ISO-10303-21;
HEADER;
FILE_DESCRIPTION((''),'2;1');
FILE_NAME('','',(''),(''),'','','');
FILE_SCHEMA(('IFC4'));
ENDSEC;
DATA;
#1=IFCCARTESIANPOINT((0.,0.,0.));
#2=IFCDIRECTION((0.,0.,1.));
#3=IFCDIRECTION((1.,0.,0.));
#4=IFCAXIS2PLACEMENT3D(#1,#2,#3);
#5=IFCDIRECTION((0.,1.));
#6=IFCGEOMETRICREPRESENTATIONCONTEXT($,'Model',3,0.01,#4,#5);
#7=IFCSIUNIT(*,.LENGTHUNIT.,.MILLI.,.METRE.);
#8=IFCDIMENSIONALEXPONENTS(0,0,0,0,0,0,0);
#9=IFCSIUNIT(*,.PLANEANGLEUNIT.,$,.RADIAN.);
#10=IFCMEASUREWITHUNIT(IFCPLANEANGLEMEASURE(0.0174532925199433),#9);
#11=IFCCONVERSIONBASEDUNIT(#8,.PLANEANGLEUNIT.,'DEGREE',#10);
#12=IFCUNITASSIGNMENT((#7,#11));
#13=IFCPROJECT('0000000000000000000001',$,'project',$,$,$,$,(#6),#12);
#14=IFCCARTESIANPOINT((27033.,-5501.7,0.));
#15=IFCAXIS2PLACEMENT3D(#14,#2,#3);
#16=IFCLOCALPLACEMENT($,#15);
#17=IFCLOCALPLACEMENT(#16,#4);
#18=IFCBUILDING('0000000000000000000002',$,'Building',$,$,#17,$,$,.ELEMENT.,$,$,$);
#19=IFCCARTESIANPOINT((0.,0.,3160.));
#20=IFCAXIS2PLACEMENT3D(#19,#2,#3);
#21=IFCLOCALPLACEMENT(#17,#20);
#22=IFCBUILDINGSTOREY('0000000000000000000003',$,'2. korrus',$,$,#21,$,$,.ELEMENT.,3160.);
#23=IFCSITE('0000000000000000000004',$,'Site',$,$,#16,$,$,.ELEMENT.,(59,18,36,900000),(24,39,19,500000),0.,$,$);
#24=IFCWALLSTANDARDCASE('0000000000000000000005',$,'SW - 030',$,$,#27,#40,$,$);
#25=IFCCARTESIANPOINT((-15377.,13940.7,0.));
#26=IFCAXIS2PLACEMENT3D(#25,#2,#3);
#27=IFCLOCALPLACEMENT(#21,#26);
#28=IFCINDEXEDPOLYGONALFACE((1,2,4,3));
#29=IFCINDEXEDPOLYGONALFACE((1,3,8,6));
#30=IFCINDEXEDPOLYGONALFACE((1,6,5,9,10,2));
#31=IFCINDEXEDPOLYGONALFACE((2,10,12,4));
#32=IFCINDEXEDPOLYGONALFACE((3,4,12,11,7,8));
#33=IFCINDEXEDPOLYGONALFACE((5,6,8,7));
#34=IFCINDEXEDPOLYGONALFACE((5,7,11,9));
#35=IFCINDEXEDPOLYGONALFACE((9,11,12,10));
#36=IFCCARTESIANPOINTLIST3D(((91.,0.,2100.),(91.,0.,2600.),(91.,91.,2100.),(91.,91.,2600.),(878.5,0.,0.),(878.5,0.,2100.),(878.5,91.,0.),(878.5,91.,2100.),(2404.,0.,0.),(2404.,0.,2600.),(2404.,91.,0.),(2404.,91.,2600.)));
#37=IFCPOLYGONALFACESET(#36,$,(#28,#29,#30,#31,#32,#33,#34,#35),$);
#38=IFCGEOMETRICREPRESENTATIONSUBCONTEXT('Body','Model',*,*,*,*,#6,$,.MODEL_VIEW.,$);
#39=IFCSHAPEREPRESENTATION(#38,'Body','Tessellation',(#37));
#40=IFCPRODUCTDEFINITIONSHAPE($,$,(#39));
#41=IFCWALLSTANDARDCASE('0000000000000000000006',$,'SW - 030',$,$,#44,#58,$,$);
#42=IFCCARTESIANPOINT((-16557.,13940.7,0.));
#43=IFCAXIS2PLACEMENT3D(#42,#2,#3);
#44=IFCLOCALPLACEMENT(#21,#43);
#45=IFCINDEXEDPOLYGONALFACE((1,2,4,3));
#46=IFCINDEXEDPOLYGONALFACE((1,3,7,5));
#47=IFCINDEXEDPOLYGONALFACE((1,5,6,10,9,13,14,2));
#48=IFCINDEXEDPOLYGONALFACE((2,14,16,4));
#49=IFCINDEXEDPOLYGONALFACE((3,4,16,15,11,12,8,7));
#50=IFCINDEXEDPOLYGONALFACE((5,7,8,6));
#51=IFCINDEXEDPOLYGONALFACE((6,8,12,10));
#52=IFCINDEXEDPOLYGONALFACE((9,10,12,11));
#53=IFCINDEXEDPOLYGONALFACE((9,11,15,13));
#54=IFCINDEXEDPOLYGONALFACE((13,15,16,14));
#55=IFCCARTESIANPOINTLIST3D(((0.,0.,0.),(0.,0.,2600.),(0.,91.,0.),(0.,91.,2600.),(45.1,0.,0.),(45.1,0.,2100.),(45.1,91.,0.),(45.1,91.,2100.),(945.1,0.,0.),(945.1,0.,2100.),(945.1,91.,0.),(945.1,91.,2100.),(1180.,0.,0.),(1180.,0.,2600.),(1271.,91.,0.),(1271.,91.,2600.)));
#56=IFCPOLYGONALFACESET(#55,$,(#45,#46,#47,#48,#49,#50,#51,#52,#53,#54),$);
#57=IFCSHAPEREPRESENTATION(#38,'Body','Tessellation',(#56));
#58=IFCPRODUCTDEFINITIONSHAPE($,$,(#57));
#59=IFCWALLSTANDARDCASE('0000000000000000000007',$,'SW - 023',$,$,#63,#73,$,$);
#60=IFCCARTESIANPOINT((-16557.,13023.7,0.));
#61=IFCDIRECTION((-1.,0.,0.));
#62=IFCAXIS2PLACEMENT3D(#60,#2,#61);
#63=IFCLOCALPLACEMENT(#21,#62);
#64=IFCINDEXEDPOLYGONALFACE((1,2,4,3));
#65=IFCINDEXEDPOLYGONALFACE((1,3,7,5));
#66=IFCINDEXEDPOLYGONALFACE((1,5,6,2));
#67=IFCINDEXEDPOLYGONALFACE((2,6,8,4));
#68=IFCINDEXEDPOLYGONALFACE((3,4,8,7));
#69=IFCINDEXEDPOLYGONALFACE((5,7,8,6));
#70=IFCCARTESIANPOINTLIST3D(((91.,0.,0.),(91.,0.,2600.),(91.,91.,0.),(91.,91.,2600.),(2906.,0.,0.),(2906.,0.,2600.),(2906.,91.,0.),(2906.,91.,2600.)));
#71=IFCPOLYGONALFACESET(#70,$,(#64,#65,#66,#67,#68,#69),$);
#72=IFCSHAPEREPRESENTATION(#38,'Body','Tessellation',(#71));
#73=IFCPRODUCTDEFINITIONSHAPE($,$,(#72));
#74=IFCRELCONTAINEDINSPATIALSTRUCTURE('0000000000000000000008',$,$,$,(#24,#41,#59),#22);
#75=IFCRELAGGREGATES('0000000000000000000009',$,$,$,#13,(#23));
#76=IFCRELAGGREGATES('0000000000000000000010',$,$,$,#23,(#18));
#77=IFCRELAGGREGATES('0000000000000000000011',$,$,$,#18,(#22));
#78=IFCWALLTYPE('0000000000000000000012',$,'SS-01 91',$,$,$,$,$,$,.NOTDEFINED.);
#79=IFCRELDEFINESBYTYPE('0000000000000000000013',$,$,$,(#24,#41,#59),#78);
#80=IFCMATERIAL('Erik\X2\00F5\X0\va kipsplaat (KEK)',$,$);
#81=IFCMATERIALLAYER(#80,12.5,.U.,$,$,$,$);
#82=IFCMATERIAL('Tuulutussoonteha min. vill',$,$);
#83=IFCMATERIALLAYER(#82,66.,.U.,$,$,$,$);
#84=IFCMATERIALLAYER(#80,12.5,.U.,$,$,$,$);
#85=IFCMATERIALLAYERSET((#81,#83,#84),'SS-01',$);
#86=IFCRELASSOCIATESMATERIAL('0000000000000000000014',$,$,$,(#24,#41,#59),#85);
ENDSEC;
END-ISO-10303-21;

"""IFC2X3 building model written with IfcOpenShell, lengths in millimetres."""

from ifc_helpers import new_model, entity, si_unit, converted_unit, direction, frame, origin_with_axes, origin_2d_with_axis, place, context, subcontext, project, spatial, polyline, rectangle, outline, extrude, material, layer, layer_set, layer_usage, type_object, element, save


model = new_model("IFC2X3")

# Units and contexts
model_context = context("Model", 3, precision=0.01, world=origin_with_axes(), true_north=direction((0.0, 1.0)))
body_context = subcontext(model_context, "Body", "Model", "MODEL_VIEW")
ifc_project = project(units=[si_unit("LENGTHUNIT", "METRE", prefix="MILLI"), converted_unit("PLANEANGLEUNIT", "DEGREE", entity("IfcPlaneAngleMeasure", 0.0174532925199433), si_unit("PLANEANGLEUNIT", "RADIAN"), dimensions=[0, 0, 0, 0, 0, 0, 0])], contexts=[model_context])

# Site, building, storey
site_placement = place(None, frame((27033.0, -5501.7, 0.0), z_axis=(0.0, 0.0, 1.0), x_axis=(1.0, 0.0, 0.0)))
site = spatial("IfcSite", under=ifc_project, at=site_placement, Name="Site", CompositionType="ELEMENT", RefLatitude=(59, 18, 36, 900000), RefLongitude=(24, 39, 19, 500000), RefElevation=0.0)
building_placement = place(site_placement, origin_with_axes())
building = spatial("IfcBuilding", under=site, at=building_placement, Name="Building", CompositionType="ELEMENT")
storey_placement = place(building_placement, frame((0.0, 0.0, 3160.0), z_axis=(0.0, 0.0, 1.0), x_axis=(1.0, 0.0, 0.0)))
storey = spatial("IfcBuildingStorey", under=building, at=storey_placement, Name="2. korrus", CompositionType="ELEMENT", Elevation=3160.0)

# Shared definitions
ifc_material_1 = material(Name="Erikõva kipsplaat (KEK)")
ifc_layer_1 = layer(ifc_material_1, 12.5, ventilated="UNKNOWN")
ifc_material_2 = material(Name="Tuulutussoonteha min. vill")
ifc_layer_2 = layer(ifc_material_2, 66.0, ventilated="UNKNOWN")
ifc_layer_3 = layer(ifc_material_1, 12.5, ventilated="UNKNOWN")
ifc_layer_set_1 = layer_set([ifc_layer_1, ifc_layer_2, ifc_layer_3], Name="SS-01")
wall_type_1 = type_object("IfcWallType", Name="SS-01 91", PredefinedType="NOTDEFINED")

# Walls, openings
ifc_layer_usage_1 = layer_usage(ifc_layer_set_1, "AXIS2", "NEGATIVE", 91.0)
wall_1_placement = place(storey_placement, frame((-15377.0, 13940.7, 0.0), z_axis=(0.0, 0.0, 1.0), x_axis=(1.0, 0.0, 0.0)))
wall_1 = element("IfcWallStandardCase", 1, at=wall_1_placement, inside=storey, type_object=wall_type_1, material=ifc_layer_usage_1, Name="SW - 030", context=body_context, shape_type="SweptSolid", body=[
    extrude(outline(polyline([(91.0, 0.0), (2404.0, 0.0), (2404.0, 91.0), (91.0, 91.0), (91.0, 0.0)])), origin_with_axes(), (0.0, 0.0, 1.0), 2600.0),
])
opening_1_placement = place(wall_1_placement, frame((478.5, 0.0, 0.0), z_axis=(0.0, 0.0, 1.0), x_axis=(1.0, 0.0, 0.0)))
element("IfcOpeningElement", 2, at=opening_1_placement, cuts=wall_1, context=body_context, shape_type="SweptSolid", body=[
    extrude(rectangle(XDim=800.0, YDim=2100.0, at=origin_2d_with_axis()), frame((0.0, -91.0, 1050.0), z_axis=(0.0, 1.0, 0.0), x_axis=(1.0, 0.0, 0.0)), (0.0, 0.0, 1.0), 273.0),
])
ifc_layer_usage_2 = layer_usage(ifc_layer_set_1, "AXIS2", "NEGATIVE", 91.0)
wall_2_placement = place(storey_placement, frame((-16557.0, 13940.7, 0.0), z_axis=(0.0, 0.0, 1.0), x_axis=(1.0, 0.0, 0.0)))
wall_2 = element("IfcWallStandardCase", 3, at=wall_2_placement, inside=storey, type_object=wall_type_1, material=ifc_layer_usage_2, Name="SW - 030", context=body_context, shape_type="SweptSolid", body=[
    extrude(outline(polyline([(0.0, 0.0), (1180.0, 0.0), (1271.0, 91.0), (0.0, 91.0), (0.0, 0.0)])), origin_with_axes(), (0.0, 0.0, 1.0), 2600.0),
])
opening_2_placement = place(wall_2_placement, frame((495.1, 0.0, 0.0), z_axis=(0.0, 0.0, 1.0), x_axis=(1.0, 0.0, 0.0)))
element("IfcOpeningElement", 4, at=opening_2_placement, cuts=wall_2, context=body_context, shape_type="SweptSolid", body=[
    extrude(rectangle(XDim=900.0, YDim=2100.0, at=origin_2d_with_axis()), frame((0.0, -91.0, 1050.0), z_axis=(0.0, -1.0, 0.0), x_axis=(-1.0, 0.0, 0.0)), (0.0, 0.0, -1.0), 273.0),
    extrude(rectangle(XDim=974.0, YDim=2137.0, at=origin_2d_with_axis()), frame((0.0, 91.0, 1068.5), z_axis=(0.0, 1.0, 0.0), x_axis=(-1.0, 0.0, 0.0)), (0.0, 0.0, 1.0), 91.0),
])

# Wall
ifc_layer_usage_3 = layer_usage(ifc_layer_set_1, "AXIS2", "NEGATIVE", 91.0)
wall_3_placement = place(storey_placement, frame((-16557.0, 13023.7, 0.0), z_axis=(0.0, 0.0, 1.0), x_axis=(-1.0, 0.0, 0.0)))
element("IfcWallStandardCase", 5, at=wall_3_placement, inside=storey, type_object=wall_type_1, material=ifc_layer_usage_3, Name="SW - 023", context=body_context, shape_type="SweptSolid", body=[
    extrude(outline(polyline([(91.0, 0.0), (2906.0, 0.0), (2906.0, 91.0), (91.0, 91.0), (91.0, 0.0)])), origin_with_axes(), (0.0, 0.0, 1.0), 2600.0),
])

save(model, "model.ifc")
